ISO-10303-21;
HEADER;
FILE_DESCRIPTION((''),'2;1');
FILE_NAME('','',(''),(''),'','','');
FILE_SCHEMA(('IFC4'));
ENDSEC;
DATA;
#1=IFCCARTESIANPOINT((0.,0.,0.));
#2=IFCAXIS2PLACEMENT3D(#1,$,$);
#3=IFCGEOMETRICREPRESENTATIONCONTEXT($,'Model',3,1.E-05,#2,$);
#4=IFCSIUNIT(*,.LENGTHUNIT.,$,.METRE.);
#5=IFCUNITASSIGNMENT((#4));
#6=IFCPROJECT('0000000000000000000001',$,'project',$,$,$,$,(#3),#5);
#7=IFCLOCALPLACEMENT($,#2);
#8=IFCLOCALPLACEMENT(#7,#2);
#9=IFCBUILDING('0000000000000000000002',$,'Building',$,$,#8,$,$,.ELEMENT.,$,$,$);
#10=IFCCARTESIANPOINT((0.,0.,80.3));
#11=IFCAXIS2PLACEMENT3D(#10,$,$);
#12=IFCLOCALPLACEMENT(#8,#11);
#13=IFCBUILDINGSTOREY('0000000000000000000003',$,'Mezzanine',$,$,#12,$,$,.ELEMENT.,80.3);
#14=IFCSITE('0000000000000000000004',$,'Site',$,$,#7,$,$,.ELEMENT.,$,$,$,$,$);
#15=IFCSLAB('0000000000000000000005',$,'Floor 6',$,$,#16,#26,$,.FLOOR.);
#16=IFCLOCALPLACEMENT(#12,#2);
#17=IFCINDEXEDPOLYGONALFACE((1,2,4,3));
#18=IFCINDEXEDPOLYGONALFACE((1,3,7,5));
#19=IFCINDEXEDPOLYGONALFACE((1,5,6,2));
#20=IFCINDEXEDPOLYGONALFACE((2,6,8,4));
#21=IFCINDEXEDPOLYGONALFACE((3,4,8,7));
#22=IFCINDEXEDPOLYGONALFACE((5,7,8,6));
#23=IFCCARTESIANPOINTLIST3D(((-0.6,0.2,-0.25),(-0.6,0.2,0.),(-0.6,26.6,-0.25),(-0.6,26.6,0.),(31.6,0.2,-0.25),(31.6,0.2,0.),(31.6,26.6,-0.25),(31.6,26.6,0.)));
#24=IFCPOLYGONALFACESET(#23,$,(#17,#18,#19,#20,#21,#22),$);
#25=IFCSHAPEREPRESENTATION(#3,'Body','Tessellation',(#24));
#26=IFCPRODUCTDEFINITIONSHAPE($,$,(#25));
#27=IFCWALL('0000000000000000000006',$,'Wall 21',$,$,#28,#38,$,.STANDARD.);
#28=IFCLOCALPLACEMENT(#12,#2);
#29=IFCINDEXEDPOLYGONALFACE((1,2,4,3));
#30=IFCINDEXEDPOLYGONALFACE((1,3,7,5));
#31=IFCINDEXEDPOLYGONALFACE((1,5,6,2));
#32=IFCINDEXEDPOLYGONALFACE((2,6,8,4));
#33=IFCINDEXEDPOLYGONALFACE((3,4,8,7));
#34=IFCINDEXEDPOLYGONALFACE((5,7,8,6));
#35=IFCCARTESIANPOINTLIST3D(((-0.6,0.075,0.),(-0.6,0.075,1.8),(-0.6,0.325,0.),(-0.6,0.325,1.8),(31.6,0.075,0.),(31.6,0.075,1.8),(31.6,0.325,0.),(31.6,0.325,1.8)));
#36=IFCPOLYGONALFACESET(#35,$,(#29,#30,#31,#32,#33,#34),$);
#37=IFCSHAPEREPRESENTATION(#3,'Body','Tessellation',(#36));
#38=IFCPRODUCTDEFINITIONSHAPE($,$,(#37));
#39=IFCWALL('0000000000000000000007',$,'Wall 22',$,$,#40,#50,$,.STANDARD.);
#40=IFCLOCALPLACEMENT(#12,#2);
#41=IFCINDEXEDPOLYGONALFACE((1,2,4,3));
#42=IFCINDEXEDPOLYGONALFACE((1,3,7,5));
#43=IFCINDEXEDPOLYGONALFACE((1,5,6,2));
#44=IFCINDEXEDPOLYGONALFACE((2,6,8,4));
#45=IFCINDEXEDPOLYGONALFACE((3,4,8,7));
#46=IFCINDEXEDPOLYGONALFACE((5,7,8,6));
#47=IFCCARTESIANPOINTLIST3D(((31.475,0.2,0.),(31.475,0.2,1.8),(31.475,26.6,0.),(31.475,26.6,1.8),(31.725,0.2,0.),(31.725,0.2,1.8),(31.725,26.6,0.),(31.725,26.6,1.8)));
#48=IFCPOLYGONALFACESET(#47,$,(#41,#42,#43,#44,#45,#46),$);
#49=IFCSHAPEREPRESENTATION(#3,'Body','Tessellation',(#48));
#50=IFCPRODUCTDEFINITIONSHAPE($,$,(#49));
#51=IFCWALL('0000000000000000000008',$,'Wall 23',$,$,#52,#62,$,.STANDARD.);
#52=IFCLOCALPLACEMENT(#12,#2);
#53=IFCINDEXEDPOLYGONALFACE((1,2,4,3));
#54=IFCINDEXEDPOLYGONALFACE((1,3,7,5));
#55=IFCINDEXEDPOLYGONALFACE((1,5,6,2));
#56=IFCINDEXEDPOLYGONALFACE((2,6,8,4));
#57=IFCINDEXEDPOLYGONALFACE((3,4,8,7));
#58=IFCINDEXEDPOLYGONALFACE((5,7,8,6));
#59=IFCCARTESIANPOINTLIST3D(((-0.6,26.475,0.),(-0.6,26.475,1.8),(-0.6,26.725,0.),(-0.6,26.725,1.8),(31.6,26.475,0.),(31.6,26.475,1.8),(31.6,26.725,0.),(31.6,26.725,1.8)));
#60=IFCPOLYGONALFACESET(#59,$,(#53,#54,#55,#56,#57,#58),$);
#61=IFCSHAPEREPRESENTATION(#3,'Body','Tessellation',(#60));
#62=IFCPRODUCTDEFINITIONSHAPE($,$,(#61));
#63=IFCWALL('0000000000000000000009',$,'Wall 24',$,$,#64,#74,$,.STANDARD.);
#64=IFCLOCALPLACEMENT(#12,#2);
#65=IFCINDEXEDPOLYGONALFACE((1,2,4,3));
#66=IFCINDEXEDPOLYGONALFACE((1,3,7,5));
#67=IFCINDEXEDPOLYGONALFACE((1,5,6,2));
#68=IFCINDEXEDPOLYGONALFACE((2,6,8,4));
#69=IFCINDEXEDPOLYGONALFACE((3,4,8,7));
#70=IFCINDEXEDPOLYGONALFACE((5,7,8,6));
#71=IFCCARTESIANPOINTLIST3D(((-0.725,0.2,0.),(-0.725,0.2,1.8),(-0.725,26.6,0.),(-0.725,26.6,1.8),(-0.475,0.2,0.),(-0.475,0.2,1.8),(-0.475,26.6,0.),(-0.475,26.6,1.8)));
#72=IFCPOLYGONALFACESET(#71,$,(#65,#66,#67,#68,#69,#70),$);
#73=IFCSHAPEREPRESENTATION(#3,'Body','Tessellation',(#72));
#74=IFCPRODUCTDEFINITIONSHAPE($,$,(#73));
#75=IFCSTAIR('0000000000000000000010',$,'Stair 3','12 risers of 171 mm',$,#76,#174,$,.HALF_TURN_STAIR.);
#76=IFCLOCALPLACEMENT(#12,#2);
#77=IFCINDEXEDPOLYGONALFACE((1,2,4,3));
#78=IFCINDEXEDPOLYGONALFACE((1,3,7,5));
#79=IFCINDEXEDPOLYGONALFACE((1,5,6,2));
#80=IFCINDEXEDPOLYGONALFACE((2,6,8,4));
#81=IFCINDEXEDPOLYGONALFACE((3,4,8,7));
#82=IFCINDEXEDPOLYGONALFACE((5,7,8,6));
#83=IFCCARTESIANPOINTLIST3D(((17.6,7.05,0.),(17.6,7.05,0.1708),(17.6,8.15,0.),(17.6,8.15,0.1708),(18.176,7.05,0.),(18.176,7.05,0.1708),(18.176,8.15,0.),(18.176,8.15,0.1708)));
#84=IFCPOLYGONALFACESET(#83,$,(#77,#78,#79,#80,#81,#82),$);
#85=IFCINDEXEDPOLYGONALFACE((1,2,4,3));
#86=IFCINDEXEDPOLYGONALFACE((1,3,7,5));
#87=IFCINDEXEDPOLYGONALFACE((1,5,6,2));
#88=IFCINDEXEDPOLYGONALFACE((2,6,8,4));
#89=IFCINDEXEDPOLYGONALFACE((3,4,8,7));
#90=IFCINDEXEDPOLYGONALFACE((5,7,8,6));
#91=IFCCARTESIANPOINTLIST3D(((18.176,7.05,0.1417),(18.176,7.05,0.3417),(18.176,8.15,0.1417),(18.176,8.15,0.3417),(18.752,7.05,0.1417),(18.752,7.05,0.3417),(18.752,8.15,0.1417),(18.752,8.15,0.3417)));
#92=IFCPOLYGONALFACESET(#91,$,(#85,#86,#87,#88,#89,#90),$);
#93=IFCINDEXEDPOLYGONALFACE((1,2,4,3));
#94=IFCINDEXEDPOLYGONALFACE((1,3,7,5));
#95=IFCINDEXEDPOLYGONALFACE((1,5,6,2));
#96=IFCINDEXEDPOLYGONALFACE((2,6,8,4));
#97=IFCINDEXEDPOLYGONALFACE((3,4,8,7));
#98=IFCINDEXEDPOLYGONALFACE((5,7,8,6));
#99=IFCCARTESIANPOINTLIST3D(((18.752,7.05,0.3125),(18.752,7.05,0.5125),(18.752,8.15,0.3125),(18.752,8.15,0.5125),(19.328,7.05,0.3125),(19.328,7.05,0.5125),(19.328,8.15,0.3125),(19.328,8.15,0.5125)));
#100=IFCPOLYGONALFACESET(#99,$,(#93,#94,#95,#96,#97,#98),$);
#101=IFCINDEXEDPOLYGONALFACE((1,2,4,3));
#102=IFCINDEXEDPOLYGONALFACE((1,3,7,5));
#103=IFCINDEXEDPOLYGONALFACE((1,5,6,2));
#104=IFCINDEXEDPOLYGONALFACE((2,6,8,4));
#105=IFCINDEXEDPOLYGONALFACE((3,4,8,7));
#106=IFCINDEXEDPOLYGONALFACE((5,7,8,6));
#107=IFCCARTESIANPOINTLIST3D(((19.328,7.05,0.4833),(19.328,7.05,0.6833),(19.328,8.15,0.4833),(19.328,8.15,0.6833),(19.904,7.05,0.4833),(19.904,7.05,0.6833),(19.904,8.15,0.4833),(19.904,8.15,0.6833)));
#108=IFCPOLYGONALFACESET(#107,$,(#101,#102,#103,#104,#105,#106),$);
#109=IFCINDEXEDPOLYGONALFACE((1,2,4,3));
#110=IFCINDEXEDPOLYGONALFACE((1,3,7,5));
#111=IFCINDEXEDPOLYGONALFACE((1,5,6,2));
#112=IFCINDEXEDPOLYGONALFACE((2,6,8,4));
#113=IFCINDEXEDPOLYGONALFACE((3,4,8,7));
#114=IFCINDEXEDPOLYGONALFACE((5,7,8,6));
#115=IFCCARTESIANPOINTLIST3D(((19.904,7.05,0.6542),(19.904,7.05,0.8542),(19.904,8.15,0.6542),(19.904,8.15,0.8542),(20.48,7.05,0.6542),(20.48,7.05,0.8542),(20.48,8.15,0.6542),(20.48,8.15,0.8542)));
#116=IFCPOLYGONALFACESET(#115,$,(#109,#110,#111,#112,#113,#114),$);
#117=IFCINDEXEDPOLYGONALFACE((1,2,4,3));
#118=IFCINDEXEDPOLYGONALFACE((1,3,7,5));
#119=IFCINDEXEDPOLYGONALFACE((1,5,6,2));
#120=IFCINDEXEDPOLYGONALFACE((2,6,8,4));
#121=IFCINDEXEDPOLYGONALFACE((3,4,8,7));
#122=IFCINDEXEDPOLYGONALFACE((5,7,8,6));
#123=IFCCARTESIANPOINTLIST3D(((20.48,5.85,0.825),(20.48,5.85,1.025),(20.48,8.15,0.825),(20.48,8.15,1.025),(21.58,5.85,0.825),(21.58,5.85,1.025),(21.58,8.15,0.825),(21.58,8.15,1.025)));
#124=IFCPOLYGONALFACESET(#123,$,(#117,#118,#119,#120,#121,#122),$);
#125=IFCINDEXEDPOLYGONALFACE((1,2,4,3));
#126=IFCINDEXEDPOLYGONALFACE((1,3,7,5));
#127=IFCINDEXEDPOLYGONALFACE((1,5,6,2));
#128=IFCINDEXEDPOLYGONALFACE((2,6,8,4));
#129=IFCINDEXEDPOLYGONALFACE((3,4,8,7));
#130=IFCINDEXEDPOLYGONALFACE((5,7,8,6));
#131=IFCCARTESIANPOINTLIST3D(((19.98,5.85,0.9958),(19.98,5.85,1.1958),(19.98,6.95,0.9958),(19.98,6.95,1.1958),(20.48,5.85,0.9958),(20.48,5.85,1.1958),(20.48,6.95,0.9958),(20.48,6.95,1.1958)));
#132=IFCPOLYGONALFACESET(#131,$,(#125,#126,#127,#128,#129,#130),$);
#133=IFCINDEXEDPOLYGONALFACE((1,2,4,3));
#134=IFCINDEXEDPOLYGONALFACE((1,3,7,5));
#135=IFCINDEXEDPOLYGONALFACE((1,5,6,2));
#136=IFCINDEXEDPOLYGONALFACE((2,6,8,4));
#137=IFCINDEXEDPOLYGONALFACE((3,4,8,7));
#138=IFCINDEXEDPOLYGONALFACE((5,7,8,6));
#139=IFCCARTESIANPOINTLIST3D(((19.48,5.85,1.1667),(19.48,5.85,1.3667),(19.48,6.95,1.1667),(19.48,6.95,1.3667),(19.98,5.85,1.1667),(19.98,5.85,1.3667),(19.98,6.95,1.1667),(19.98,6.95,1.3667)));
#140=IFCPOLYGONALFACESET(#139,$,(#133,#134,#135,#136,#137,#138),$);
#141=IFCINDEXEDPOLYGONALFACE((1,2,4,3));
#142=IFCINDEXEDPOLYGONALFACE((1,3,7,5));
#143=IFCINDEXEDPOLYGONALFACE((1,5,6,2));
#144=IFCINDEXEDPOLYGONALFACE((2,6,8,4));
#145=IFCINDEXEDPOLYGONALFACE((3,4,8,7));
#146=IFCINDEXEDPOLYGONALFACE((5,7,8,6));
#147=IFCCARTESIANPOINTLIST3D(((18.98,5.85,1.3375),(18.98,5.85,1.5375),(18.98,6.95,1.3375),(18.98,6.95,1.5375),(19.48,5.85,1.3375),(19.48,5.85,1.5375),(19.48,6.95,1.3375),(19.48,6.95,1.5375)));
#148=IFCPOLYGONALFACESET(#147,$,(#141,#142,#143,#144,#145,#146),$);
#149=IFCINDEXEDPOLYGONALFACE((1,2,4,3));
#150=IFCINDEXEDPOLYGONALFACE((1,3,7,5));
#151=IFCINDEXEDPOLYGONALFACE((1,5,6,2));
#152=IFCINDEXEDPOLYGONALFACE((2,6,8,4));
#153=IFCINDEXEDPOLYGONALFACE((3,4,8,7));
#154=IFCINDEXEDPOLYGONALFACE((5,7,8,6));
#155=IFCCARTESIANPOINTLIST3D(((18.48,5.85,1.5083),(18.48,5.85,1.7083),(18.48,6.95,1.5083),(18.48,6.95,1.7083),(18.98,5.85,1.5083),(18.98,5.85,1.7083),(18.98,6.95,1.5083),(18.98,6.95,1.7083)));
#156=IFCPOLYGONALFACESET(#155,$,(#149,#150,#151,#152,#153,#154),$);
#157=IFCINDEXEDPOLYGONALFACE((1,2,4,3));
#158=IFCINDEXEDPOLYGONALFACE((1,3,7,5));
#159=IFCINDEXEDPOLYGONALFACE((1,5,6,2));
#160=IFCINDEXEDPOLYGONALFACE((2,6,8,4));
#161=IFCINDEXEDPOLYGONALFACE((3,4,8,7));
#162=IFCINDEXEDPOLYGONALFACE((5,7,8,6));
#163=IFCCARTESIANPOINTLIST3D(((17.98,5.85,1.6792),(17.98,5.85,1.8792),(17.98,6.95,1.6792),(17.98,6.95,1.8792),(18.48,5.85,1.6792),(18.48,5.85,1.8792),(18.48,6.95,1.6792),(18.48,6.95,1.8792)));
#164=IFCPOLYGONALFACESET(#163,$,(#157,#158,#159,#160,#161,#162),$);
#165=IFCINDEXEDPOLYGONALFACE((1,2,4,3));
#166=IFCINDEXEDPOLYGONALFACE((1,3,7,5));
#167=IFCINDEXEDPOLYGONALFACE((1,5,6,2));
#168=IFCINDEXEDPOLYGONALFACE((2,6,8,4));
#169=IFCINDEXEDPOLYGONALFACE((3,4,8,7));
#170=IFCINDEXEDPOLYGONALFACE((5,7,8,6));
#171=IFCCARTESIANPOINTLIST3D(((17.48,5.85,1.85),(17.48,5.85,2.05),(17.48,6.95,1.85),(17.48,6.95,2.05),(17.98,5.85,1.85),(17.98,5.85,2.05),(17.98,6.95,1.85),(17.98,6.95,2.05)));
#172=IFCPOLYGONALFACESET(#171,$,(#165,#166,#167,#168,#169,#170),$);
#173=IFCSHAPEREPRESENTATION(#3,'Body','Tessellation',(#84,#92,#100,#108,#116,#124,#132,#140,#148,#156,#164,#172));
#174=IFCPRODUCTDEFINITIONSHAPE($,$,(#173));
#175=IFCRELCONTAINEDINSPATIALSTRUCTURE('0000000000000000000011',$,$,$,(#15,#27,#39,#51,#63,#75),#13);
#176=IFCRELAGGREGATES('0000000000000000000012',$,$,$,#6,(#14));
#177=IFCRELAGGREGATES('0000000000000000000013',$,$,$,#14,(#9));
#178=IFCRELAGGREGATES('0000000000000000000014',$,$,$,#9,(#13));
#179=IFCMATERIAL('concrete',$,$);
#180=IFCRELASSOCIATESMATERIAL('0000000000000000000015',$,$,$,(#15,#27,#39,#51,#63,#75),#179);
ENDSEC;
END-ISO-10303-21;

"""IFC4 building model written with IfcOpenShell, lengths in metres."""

from ifc_helpers import new_model, si_unit, frame, frame_2d, origin, place, context, project, spatial, polyline, rectangle, outline, extrude, material, element, save


model = new_model("IFC4")

# Units and contexts
model_context = context("Model", 3, precision=1e-05, world=origin())
ifc_project = project(units=[si_unit("LENGTHUNIT", "METRE")], contexts=[model_context])

# Site, building, storey
site_placement = place(None, origin())
site = spatial("IfcSite", under=ifc_project, at=site_placement, Name="Site", CompositionType="ELEMENT")
building_placement = place(site_placement, origin())
building = spatial("IfcBuilding", under=site, at=building_placement, Name="Building", CompositionType="ELEMENT")
storey_placement = place(building_placement, frame((0.0, 0.0, 80.3)))
storey = spatial("IfcBuildingStorey", under=building, at=storey_placement, Name="Mezzanine", CompositionType="ELEMENT", Elevation=80.3)

# Slab
ifc_material = material(Name="concrete")
slab_placement = place(storey_placement, frame((0.0, 0.0, -0.25), z_axis=(0.0, 0.0, 1.0), x_axis=(1.0, 0.0, 0.0)))
element("IfcSlab", 1, at=slab_placement, inside=storey, material=ifc_material, Name="Floor 6", PredefinedType="FLOOR", context=model_context, shape_type="SweptSolid", body=[
    extrude(outline(polyline([(-0.6, 0.2), (31.6, 0.2), (31.6, 26.6), (-0.6, 26.6), (-0.6, 0.2)])), origin(), (0.0, 0.0, 1.0), 0.25),
])

# Walls
wall_1_placement = place(storey_placement, frame((-0.6, 0.2, 0.0), z_axis=(0.0, 0.0, 1.0), x_axis=(1.0, 0.0, 0.0)))
element("IfcWall", 2, at=wall_1_placement, inside=storey, material=ifc_material, Name="Wall 21", PredefinedType="STANDARD", context=model_context, shape_type="SweptSolid", body=[
    extrude(rectangle(XDim=32.2, YDim=0.25, at=frame_2d((16.1, 0.0))), origin(), (0.0, 0.0, 1.0), 1.8),
])
wall_2_placement = place(storey_placement, frame((31.6, 0.2, 0.0), z_axis=(0.0, 0.0, 1.0), x_axis=(0.0, 1.0, 0.0)))
element("IfcWall", 3, at=wall_2_placement, inside=storey, material=ifc_material, Name="Wall 22", PredefinedType="STANDARD", context=model_context, shape_type="SweptSolid", body=[
    extrude(rectangle(XDim=26.4, YDim=0.25, at=frame_2d((13.2, 0.0))), origin(), (0.0, 0.0, 1.0), 1.8),
])
wall_3_placement = place(storey_placement, frame((31.6, 26.6, 0.0), z_axis=(0.0, 0.0, 1.0), x_axis=(-1.0, 0.0, 0.0)))
element("IfcWall", 4, at=wall_3_placement, inside=storey, material=ifc_material, Name="Wall 23", PredefinedType="STANDARD", context=model_context, shape_type="SweptSolid", body=[
    extrude(rectangle(XDim=32.2, YDim=0.25, at=frame_2d((16.1, 0.0))), origin(), (0.0, 0.0, 1.0), 1.8),
])
wall_4_placement = place(storey_placement, frame((-0.6, 26.6, 0.0), z_axis=(0.0, 0.0, 1.0), x_axis=(0.0, -1.0, 0.0)))
element("IfcWall", 5, at=wall_4_placement, inside=storey, material=ifc_material, Name="Wall 24", PredefinedType="STANDARD", context=model_context, shape_type="SweptSolid", body=[
    extrude(rectangle(XDim=26.4, YDim=0.25, at=frame_2d((13.2, 0.0))), origin(), (0.0, 0.0, 1.0), 1.8),
])

# Stair
stair_1_placement = place(storey_placement, frame((17.6, 7.6, 0.0), z_axis=(0.0, 0.0, 1.0), x_axis=(1.0, 0.0, 0.0)))
element("IfcStair", 6, at=stair_1_placement, inside=storey, material=ifc_material, Name="Stair 3", Description="12 risers of 171 mm", PredefinedType="HALF_TURN_STAIR", context=model_context, shape_type="SweptSolid", body=[
    extrude(outline(polyline([(0.0, -0.55), (0.576, -0.55), (0.576, 0.55), (0.0, 0.55), (0.0, -0.55)])), origin(), (0.0, 0.0, 1.0), 0.1708),
    extrude(outline(polyline([(0.576, -0.55), (1.152, -0.55), (1.152, 0.55), (0.576, 0.55), (0.576, -0.55)])), frame((0.0, 0.0, 0.1417)), (0.0, 0.0, 1.0), 0.2),
    extrude(outline(polyline([(1.152, -0.55), (1.728, -0.55), (1.728, 0.55), (1.152, 0.55), (1.152, -0.55)])), frame((0.0, 0.0, 0.3125)), (0.0, 0.0, 1.0), 0.2),
    extrude(outline(polyline([(1.728, -0.55), (2.304, -0.55), (2.304, 0.55), (1.728, 0.55), (1.728, -0.55)])), frame((0.0, 0.0, 0.4833)), (0.0, 0.0, 1.0), 0.2),
    extrude(outline(polyline([(2.304, -0.55), (2.88, -0.55), (2.88, 0.55), (2.304, 0.55), (2.304, -0.55)])), frame((0.0, 0.0, 0.6542)), (0.0, 0.0, 1.0), 0.2),
    extrude(outline(polyline([(2.88, -1.75), (3.98, -1.75), (3.98, 0.55), (2.88, 0.55), (2.88, -1.75)])), frame((0.0, 0.0, 0.825)), (0.0, 0.0, 1.0), 0.2),
    extrude(outline(polyline([(2.38, -1.75), (2.88, -1.75), (2.88, -0.65), (2.38, -0.65), (2.38, -1.75)])), frame((0.0, 0.0, 0.9958)), (0.0, 0.0, 1.0), 0.2),
    extrude(outline(polyline([(1.88, -1.75), (2.38, -1.75), (2.38, -0.65), (1.88, -0.65), (1.88, -1.75)])), frame((0.0, 0.0, 1.1667)), (0.0, 0.0, 1.0), 0.2),
    extrude(outline(polyline([(1.38, -1.75), (1.88, -1.75), (1.88, -0.65), (1.38, -0.65), (1.38, -1.75)])), frame((0.0, 0.0, 1.3375)), (0.0, 0.0, 1.0), 0.2),
    extrude(outline(polyline([(0.88, -1.75), (1.38, -1.75), (1.38, -0.65), (0.88, -0.65), (0.88, -1.75)])), frame((0.0, 0.0, 1.5083)), (0.0, 0.0, 1.0), 0.2),
    extrude(outline(polyline([(0.38, -1.75), (0.88, -1.75), (0.88, -0.65), (0.38, -0.65), (0.38, -1.75)])), frame((0.0, 0.0, 1.6792)), (0.0, 0.0, 1.0), 0.2),
    extrude(outline(polyline([(-0.12, -1.75), (0.38, -1.75), (0.38, -0.65), (-0.12, -0.65), (-0.12, -1.75)])), frame((0.0, 0.0, 1.85)), (0.0, 0.0, 1.0), 0.2),
])

save(model, "model.ifc")
